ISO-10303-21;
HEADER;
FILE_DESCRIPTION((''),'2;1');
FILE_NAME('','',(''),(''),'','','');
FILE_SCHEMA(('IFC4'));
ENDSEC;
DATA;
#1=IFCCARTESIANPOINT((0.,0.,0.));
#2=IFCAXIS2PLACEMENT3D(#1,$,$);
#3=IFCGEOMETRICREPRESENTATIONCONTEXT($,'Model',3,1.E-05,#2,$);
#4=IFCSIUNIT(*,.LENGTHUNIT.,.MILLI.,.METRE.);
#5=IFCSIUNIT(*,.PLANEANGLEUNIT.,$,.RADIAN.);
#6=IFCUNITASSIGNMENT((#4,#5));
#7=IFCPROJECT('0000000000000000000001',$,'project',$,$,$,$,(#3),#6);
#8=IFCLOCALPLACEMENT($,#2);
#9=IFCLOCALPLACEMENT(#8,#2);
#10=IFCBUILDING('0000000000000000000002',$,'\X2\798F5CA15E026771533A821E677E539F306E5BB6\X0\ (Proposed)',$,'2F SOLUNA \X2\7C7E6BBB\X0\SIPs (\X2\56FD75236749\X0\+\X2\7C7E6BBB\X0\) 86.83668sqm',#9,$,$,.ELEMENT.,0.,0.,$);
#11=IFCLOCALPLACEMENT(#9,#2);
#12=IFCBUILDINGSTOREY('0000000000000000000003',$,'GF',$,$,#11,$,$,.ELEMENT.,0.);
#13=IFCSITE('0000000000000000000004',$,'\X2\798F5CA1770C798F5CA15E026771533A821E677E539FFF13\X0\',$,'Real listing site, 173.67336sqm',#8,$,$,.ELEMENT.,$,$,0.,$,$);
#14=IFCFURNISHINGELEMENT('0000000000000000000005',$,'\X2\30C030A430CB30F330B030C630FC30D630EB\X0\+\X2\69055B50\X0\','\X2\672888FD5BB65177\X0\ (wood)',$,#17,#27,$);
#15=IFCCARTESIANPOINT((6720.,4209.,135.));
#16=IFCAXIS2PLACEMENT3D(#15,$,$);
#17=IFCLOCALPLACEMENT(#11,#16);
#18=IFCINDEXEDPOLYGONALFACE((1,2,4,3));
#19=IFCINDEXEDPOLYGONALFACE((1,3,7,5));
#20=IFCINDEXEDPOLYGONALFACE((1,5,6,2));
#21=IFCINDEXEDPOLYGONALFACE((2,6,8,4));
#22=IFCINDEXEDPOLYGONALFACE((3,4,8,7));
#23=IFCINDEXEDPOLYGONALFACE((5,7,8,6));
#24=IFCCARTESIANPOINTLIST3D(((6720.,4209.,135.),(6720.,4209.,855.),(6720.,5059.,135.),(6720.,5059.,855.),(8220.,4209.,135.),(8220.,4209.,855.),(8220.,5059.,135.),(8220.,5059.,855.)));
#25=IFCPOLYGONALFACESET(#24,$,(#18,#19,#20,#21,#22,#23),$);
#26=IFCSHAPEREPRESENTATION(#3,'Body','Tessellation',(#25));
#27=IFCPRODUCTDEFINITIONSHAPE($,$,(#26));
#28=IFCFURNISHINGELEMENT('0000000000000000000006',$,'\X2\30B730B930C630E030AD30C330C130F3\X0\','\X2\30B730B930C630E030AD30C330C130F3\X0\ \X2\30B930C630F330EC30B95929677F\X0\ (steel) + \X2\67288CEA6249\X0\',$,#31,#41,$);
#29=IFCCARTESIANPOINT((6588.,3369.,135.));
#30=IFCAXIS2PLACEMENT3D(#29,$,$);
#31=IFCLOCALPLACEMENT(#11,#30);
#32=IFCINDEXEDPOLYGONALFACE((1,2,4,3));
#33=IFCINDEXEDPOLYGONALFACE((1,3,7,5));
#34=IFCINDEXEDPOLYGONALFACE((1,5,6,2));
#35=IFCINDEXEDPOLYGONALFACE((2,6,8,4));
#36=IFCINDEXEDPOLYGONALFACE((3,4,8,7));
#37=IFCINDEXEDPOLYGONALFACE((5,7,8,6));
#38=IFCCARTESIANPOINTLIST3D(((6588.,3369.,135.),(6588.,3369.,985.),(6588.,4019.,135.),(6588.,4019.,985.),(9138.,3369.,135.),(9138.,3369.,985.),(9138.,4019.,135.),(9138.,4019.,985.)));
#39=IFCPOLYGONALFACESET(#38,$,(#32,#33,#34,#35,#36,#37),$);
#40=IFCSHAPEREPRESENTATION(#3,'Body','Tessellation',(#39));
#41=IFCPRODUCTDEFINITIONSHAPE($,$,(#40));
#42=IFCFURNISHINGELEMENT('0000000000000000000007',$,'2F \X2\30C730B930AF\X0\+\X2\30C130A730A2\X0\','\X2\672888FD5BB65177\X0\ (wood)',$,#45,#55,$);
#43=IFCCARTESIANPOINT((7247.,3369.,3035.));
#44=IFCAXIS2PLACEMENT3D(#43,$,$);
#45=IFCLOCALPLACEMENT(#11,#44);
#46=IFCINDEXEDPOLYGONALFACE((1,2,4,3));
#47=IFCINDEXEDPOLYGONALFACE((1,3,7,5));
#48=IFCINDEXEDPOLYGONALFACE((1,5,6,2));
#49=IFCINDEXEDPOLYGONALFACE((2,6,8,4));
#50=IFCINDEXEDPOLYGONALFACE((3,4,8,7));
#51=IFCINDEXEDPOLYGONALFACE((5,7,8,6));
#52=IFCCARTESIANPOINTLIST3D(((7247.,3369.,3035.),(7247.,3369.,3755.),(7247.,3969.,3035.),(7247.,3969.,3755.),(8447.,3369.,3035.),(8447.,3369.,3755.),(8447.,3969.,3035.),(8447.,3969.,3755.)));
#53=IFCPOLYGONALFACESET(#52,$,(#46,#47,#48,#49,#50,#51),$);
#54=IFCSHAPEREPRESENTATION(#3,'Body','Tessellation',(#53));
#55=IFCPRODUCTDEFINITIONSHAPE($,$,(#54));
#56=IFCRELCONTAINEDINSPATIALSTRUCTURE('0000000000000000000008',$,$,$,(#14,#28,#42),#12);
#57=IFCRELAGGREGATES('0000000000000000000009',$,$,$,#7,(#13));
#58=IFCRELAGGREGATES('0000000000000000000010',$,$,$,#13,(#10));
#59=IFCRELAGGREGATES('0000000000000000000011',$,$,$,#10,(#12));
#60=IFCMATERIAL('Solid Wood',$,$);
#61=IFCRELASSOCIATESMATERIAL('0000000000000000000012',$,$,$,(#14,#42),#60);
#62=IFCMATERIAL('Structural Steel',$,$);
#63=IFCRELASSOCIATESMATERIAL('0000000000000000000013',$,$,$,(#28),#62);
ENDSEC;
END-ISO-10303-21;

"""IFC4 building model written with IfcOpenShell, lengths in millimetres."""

from ifc_helpers import new_model, si_unit, frame, frame_2d, origin, place, context, project, spatial, rectangle, extrude, material, element, save


model = new_model("IFC4")

# Units and contexts
model_context = context("Model", 3, precision=1e-05, world=origin())
ifc_project = project(units=[si_unit("LENGTHUNIT", "METRE", prefix="MILLI"), si_unit("PLANEANGLEUNIT", "RADIAN")], contexts=[model_context])

# Site, building, storey
site_placement = place(None, origin())
site = spatial("IfcSite", under=ifc_project, at=site_placement, Name="福岡県福岡市東区舞松原３", ObjectType="Real listing site, 173.67336sqm", CompositionType="ELEMENT", RefElevation=0.0)
building_placement = place(site_placement, origin())
building = spatial("IfcBuilding", under=site, at=building_placement, Name="福岡市東区舞松原の家 (Proposed)", ObjectType="2F SOLUNA 籾殻SIPs (国産杉+籾殻) 86.83668sqm", CompositionType="ELEMENT", ElevationOfRefHeight=0.0, ElevationOfTerrain=0.0)
storey_placement = place(building_placement, origin())
storey = spatial("IfcBuildingStorey", under=building, at=storey_placement, Name="GF", CompositionType="ELEMENT", Elevation=0.0)

# Shared definitions
ifc_material_1 = material(Name="Solid Wood")

# Shared definitions
ifc_material_2 = material(Name="Structural Steel")

# Furnishing elements
furnishing_1_placement = place(storey_placement, frame((6720.0, 4209.0, 135.0)))
element("IfcFurnishingElement", 1, at=furnishing_1_placement, inside=storey, material=ifc_material_1, Name="ダイニングテーブル+椅子", Description="木製家具 (wood)", context=model_context, shape_type="SweptSolid", body=[
    extrude(rectangle(XDim=1500.0, YDim=850.0, at=frame_2d((750.0, 425.0))), frame((6720.0, 4209.0, 135.0)), (0.0, 0.0, 1.0), 720.0),
])
furnishing_2_placement = place(storey_placement, frame((6588.0, 3369.0, 135.0)))
element("IfcFurnishingElement", 2, at=furnishing_2_placement, inside=storey, material=ifc_material_2, Name="システムキッチン", Description="システムキッチン ステンレス天板 (steel) + 木質扉", context=model_context, shape_type="SweptSolid", body=[
    extrude(rectangle(XDim=2550.0, YDim=650.0, at=frame_2d((1275.0, 325.0))), frame((6588.0, 3369.0, 135.0)), (0.0, 0.0, 1.0), 850.0),
])
furnishing_3_placement = place(storey_placement, frame((7247.0, 3369.0, 3035.0)))
element("IfcFurnishingElement", 3, at=furnishing_3_placement, inside=storey, material=ifc_material_1, Name="2F デスク+チェア", Description="木製家具 (wood)", context=model_context, shape_type="SweptSolid", body=[
    extrude(rectangle(XDim=1200.0, YDim=600.0, at=frame_2d((600.0, 300.0))), frame((7247.0, 3369.0, 3035.0)), (0.0, 0.0, 1.0), 720.0),
])

save(model, "model.ifc")
